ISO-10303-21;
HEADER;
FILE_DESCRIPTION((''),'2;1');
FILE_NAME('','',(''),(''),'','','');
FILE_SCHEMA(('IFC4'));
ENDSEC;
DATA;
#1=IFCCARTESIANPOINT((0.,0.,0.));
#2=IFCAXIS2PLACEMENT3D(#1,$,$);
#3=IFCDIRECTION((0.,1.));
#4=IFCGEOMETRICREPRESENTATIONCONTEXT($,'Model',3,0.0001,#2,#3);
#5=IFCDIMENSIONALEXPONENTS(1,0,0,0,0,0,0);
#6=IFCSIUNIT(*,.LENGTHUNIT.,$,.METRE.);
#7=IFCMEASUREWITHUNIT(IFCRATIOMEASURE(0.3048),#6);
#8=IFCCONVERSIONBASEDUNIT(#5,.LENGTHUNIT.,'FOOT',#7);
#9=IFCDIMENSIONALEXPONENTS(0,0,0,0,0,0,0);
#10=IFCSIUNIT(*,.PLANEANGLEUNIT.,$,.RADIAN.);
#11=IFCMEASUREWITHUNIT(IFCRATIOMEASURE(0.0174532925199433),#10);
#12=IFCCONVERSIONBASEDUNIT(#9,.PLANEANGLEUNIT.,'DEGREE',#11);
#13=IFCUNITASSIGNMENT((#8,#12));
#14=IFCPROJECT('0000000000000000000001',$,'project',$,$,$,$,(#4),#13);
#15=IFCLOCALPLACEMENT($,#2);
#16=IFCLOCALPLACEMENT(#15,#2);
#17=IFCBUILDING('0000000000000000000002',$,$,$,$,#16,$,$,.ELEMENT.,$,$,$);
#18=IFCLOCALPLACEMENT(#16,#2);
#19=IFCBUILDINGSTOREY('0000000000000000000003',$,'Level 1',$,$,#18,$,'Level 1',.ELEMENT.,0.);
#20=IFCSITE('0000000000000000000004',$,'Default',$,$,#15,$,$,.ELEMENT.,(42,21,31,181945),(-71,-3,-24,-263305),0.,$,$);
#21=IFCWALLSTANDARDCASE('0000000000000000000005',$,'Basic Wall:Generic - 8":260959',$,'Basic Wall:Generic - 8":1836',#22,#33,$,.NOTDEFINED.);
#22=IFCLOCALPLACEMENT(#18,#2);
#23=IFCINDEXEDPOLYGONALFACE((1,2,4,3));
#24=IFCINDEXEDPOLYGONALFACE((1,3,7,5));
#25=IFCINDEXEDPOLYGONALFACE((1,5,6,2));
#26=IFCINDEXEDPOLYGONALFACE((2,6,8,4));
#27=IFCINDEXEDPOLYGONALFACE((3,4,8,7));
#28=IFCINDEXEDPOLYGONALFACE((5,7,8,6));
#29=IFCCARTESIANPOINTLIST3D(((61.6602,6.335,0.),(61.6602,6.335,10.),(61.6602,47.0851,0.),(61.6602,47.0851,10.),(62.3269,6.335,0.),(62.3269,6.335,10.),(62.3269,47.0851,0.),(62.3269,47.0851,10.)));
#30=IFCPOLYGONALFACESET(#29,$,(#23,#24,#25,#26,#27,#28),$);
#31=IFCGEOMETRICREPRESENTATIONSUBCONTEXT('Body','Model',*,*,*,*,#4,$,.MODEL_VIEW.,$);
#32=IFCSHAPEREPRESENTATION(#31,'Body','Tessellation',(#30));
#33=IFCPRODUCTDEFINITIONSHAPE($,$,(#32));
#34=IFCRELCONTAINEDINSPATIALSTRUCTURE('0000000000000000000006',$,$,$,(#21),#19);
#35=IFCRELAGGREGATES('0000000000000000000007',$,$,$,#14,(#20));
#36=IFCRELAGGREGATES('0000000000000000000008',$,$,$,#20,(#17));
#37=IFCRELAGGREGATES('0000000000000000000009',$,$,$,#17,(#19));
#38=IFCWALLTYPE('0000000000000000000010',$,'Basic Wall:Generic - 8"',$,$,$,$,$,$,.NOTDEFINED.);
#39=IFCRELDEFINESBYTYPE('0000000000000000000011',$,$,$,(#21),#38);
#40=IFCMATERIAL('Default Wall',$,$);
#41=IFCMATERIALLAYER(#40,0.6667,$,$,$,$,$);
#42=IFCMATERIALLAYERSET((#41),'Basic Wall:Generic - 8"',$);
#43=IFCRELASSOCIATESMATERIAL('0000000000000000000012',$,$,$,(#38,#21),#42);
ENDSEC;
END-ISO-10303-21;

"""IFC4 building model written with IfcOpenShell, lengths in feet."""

from ifc_helpers import new_model, entity, si_unit, converted_unit, direction, frame, frame_2d, origin, place, context, subcontext, project, spatial, rectangle, extrude, material, layer, layer_set, layer_usage, type_object, element, save


model = new_model("IFC4")

# Units and contexts
model_context = context("Model", 3, precision=0.0001, world=origin(), true_north=direction((0.0, 1.0)))
body_context = subcontext(model_context, "Body", "Model", "MODEL_VIEW")
ifc_project = project(units=[converted_unit("LENGTHUNIT", "FOOT", entity("IfcRatioMeasure", 0.3048), si_unit("LENGTHUNIT", "METRE"), dimensions=[1, 0, 0, 0, 0, 0, 0]), converted_unit("PLANEANGLEUNIT", "DEGREE", entity("IfcRatioMeasure", 0.0174532925199433), si_unit("PLANEANGLEUNIT", "RADIAN"), dimensions=[0, 0, 0, 0, 0, 0, 0])], contexts=[model_context])

# Site, building, storey
site_placement = place(None, origin())
site = spatial("IfcSite", under=ifc_project, at=site_placement, Name="Default", CompositionType="ELEMENT", RefLatitude=(42, 21, 31, 181945), RefLongitude=(-71, -3, -24, -263305), RefElevation=0.0)
building_placement = place(site_placement, origin())
building = spatial("IfcBuilding", under=site, at=building_placement, CompositionType="ELEMENT")
storey_placement = place(building_placement, origin())
storey = spatial("IfcBuildingStorey", under=building, at=storey_placement, Name="Level 1", LongName="Level 1", CompositionType="ELEMENT", Elevation=0.0)

# Wall
ifc_material_1 = material(Name="Default Wall")
ifc_layer = layer(ifc_material_1, 0.6667)
ifc_layer_set = layer_set([ifc_layer], Name="Basic Wall:Generic - 8\"")
ifc_layer_usage = layer_usage(ifc_layer_set, "AXIS2", "NEGATIVE", 0.3333)
wall_type = type_object("IfcWallType", Name="Basic Wall:Generic - 8\"", PredefinedType="NOTDEFINED", material=ifc_layer_set)
wall_placement = place(storey_placement, frame((61.9936, 47.0851, 0.0), z_axis=(0.0, 0.0, 1.0), x_axis=(0.0, -1.0, 0.0)))
element("IfcWallStandardCase", 1, at=wall_placement, inside=storey, type_object=wall_type, material=ifc_layer_usage, Name="Basic Wall:Generic - 8\":260959", ObjectType="Basic Wall:Generic - 8\":1836", PredefinedType="NOTDEFINED", context=body_context, shape_type="SweptSolid", body=[
    extrude(rectangle(XDim=40.7501, YDim=0.6667, at=frame_2d((20.375, 0.0), x_axis=(-1.0, 0.0))), origin(), (0.0, 0.0, 1.0), 10.0),
])

save(model, "model.ifc")
